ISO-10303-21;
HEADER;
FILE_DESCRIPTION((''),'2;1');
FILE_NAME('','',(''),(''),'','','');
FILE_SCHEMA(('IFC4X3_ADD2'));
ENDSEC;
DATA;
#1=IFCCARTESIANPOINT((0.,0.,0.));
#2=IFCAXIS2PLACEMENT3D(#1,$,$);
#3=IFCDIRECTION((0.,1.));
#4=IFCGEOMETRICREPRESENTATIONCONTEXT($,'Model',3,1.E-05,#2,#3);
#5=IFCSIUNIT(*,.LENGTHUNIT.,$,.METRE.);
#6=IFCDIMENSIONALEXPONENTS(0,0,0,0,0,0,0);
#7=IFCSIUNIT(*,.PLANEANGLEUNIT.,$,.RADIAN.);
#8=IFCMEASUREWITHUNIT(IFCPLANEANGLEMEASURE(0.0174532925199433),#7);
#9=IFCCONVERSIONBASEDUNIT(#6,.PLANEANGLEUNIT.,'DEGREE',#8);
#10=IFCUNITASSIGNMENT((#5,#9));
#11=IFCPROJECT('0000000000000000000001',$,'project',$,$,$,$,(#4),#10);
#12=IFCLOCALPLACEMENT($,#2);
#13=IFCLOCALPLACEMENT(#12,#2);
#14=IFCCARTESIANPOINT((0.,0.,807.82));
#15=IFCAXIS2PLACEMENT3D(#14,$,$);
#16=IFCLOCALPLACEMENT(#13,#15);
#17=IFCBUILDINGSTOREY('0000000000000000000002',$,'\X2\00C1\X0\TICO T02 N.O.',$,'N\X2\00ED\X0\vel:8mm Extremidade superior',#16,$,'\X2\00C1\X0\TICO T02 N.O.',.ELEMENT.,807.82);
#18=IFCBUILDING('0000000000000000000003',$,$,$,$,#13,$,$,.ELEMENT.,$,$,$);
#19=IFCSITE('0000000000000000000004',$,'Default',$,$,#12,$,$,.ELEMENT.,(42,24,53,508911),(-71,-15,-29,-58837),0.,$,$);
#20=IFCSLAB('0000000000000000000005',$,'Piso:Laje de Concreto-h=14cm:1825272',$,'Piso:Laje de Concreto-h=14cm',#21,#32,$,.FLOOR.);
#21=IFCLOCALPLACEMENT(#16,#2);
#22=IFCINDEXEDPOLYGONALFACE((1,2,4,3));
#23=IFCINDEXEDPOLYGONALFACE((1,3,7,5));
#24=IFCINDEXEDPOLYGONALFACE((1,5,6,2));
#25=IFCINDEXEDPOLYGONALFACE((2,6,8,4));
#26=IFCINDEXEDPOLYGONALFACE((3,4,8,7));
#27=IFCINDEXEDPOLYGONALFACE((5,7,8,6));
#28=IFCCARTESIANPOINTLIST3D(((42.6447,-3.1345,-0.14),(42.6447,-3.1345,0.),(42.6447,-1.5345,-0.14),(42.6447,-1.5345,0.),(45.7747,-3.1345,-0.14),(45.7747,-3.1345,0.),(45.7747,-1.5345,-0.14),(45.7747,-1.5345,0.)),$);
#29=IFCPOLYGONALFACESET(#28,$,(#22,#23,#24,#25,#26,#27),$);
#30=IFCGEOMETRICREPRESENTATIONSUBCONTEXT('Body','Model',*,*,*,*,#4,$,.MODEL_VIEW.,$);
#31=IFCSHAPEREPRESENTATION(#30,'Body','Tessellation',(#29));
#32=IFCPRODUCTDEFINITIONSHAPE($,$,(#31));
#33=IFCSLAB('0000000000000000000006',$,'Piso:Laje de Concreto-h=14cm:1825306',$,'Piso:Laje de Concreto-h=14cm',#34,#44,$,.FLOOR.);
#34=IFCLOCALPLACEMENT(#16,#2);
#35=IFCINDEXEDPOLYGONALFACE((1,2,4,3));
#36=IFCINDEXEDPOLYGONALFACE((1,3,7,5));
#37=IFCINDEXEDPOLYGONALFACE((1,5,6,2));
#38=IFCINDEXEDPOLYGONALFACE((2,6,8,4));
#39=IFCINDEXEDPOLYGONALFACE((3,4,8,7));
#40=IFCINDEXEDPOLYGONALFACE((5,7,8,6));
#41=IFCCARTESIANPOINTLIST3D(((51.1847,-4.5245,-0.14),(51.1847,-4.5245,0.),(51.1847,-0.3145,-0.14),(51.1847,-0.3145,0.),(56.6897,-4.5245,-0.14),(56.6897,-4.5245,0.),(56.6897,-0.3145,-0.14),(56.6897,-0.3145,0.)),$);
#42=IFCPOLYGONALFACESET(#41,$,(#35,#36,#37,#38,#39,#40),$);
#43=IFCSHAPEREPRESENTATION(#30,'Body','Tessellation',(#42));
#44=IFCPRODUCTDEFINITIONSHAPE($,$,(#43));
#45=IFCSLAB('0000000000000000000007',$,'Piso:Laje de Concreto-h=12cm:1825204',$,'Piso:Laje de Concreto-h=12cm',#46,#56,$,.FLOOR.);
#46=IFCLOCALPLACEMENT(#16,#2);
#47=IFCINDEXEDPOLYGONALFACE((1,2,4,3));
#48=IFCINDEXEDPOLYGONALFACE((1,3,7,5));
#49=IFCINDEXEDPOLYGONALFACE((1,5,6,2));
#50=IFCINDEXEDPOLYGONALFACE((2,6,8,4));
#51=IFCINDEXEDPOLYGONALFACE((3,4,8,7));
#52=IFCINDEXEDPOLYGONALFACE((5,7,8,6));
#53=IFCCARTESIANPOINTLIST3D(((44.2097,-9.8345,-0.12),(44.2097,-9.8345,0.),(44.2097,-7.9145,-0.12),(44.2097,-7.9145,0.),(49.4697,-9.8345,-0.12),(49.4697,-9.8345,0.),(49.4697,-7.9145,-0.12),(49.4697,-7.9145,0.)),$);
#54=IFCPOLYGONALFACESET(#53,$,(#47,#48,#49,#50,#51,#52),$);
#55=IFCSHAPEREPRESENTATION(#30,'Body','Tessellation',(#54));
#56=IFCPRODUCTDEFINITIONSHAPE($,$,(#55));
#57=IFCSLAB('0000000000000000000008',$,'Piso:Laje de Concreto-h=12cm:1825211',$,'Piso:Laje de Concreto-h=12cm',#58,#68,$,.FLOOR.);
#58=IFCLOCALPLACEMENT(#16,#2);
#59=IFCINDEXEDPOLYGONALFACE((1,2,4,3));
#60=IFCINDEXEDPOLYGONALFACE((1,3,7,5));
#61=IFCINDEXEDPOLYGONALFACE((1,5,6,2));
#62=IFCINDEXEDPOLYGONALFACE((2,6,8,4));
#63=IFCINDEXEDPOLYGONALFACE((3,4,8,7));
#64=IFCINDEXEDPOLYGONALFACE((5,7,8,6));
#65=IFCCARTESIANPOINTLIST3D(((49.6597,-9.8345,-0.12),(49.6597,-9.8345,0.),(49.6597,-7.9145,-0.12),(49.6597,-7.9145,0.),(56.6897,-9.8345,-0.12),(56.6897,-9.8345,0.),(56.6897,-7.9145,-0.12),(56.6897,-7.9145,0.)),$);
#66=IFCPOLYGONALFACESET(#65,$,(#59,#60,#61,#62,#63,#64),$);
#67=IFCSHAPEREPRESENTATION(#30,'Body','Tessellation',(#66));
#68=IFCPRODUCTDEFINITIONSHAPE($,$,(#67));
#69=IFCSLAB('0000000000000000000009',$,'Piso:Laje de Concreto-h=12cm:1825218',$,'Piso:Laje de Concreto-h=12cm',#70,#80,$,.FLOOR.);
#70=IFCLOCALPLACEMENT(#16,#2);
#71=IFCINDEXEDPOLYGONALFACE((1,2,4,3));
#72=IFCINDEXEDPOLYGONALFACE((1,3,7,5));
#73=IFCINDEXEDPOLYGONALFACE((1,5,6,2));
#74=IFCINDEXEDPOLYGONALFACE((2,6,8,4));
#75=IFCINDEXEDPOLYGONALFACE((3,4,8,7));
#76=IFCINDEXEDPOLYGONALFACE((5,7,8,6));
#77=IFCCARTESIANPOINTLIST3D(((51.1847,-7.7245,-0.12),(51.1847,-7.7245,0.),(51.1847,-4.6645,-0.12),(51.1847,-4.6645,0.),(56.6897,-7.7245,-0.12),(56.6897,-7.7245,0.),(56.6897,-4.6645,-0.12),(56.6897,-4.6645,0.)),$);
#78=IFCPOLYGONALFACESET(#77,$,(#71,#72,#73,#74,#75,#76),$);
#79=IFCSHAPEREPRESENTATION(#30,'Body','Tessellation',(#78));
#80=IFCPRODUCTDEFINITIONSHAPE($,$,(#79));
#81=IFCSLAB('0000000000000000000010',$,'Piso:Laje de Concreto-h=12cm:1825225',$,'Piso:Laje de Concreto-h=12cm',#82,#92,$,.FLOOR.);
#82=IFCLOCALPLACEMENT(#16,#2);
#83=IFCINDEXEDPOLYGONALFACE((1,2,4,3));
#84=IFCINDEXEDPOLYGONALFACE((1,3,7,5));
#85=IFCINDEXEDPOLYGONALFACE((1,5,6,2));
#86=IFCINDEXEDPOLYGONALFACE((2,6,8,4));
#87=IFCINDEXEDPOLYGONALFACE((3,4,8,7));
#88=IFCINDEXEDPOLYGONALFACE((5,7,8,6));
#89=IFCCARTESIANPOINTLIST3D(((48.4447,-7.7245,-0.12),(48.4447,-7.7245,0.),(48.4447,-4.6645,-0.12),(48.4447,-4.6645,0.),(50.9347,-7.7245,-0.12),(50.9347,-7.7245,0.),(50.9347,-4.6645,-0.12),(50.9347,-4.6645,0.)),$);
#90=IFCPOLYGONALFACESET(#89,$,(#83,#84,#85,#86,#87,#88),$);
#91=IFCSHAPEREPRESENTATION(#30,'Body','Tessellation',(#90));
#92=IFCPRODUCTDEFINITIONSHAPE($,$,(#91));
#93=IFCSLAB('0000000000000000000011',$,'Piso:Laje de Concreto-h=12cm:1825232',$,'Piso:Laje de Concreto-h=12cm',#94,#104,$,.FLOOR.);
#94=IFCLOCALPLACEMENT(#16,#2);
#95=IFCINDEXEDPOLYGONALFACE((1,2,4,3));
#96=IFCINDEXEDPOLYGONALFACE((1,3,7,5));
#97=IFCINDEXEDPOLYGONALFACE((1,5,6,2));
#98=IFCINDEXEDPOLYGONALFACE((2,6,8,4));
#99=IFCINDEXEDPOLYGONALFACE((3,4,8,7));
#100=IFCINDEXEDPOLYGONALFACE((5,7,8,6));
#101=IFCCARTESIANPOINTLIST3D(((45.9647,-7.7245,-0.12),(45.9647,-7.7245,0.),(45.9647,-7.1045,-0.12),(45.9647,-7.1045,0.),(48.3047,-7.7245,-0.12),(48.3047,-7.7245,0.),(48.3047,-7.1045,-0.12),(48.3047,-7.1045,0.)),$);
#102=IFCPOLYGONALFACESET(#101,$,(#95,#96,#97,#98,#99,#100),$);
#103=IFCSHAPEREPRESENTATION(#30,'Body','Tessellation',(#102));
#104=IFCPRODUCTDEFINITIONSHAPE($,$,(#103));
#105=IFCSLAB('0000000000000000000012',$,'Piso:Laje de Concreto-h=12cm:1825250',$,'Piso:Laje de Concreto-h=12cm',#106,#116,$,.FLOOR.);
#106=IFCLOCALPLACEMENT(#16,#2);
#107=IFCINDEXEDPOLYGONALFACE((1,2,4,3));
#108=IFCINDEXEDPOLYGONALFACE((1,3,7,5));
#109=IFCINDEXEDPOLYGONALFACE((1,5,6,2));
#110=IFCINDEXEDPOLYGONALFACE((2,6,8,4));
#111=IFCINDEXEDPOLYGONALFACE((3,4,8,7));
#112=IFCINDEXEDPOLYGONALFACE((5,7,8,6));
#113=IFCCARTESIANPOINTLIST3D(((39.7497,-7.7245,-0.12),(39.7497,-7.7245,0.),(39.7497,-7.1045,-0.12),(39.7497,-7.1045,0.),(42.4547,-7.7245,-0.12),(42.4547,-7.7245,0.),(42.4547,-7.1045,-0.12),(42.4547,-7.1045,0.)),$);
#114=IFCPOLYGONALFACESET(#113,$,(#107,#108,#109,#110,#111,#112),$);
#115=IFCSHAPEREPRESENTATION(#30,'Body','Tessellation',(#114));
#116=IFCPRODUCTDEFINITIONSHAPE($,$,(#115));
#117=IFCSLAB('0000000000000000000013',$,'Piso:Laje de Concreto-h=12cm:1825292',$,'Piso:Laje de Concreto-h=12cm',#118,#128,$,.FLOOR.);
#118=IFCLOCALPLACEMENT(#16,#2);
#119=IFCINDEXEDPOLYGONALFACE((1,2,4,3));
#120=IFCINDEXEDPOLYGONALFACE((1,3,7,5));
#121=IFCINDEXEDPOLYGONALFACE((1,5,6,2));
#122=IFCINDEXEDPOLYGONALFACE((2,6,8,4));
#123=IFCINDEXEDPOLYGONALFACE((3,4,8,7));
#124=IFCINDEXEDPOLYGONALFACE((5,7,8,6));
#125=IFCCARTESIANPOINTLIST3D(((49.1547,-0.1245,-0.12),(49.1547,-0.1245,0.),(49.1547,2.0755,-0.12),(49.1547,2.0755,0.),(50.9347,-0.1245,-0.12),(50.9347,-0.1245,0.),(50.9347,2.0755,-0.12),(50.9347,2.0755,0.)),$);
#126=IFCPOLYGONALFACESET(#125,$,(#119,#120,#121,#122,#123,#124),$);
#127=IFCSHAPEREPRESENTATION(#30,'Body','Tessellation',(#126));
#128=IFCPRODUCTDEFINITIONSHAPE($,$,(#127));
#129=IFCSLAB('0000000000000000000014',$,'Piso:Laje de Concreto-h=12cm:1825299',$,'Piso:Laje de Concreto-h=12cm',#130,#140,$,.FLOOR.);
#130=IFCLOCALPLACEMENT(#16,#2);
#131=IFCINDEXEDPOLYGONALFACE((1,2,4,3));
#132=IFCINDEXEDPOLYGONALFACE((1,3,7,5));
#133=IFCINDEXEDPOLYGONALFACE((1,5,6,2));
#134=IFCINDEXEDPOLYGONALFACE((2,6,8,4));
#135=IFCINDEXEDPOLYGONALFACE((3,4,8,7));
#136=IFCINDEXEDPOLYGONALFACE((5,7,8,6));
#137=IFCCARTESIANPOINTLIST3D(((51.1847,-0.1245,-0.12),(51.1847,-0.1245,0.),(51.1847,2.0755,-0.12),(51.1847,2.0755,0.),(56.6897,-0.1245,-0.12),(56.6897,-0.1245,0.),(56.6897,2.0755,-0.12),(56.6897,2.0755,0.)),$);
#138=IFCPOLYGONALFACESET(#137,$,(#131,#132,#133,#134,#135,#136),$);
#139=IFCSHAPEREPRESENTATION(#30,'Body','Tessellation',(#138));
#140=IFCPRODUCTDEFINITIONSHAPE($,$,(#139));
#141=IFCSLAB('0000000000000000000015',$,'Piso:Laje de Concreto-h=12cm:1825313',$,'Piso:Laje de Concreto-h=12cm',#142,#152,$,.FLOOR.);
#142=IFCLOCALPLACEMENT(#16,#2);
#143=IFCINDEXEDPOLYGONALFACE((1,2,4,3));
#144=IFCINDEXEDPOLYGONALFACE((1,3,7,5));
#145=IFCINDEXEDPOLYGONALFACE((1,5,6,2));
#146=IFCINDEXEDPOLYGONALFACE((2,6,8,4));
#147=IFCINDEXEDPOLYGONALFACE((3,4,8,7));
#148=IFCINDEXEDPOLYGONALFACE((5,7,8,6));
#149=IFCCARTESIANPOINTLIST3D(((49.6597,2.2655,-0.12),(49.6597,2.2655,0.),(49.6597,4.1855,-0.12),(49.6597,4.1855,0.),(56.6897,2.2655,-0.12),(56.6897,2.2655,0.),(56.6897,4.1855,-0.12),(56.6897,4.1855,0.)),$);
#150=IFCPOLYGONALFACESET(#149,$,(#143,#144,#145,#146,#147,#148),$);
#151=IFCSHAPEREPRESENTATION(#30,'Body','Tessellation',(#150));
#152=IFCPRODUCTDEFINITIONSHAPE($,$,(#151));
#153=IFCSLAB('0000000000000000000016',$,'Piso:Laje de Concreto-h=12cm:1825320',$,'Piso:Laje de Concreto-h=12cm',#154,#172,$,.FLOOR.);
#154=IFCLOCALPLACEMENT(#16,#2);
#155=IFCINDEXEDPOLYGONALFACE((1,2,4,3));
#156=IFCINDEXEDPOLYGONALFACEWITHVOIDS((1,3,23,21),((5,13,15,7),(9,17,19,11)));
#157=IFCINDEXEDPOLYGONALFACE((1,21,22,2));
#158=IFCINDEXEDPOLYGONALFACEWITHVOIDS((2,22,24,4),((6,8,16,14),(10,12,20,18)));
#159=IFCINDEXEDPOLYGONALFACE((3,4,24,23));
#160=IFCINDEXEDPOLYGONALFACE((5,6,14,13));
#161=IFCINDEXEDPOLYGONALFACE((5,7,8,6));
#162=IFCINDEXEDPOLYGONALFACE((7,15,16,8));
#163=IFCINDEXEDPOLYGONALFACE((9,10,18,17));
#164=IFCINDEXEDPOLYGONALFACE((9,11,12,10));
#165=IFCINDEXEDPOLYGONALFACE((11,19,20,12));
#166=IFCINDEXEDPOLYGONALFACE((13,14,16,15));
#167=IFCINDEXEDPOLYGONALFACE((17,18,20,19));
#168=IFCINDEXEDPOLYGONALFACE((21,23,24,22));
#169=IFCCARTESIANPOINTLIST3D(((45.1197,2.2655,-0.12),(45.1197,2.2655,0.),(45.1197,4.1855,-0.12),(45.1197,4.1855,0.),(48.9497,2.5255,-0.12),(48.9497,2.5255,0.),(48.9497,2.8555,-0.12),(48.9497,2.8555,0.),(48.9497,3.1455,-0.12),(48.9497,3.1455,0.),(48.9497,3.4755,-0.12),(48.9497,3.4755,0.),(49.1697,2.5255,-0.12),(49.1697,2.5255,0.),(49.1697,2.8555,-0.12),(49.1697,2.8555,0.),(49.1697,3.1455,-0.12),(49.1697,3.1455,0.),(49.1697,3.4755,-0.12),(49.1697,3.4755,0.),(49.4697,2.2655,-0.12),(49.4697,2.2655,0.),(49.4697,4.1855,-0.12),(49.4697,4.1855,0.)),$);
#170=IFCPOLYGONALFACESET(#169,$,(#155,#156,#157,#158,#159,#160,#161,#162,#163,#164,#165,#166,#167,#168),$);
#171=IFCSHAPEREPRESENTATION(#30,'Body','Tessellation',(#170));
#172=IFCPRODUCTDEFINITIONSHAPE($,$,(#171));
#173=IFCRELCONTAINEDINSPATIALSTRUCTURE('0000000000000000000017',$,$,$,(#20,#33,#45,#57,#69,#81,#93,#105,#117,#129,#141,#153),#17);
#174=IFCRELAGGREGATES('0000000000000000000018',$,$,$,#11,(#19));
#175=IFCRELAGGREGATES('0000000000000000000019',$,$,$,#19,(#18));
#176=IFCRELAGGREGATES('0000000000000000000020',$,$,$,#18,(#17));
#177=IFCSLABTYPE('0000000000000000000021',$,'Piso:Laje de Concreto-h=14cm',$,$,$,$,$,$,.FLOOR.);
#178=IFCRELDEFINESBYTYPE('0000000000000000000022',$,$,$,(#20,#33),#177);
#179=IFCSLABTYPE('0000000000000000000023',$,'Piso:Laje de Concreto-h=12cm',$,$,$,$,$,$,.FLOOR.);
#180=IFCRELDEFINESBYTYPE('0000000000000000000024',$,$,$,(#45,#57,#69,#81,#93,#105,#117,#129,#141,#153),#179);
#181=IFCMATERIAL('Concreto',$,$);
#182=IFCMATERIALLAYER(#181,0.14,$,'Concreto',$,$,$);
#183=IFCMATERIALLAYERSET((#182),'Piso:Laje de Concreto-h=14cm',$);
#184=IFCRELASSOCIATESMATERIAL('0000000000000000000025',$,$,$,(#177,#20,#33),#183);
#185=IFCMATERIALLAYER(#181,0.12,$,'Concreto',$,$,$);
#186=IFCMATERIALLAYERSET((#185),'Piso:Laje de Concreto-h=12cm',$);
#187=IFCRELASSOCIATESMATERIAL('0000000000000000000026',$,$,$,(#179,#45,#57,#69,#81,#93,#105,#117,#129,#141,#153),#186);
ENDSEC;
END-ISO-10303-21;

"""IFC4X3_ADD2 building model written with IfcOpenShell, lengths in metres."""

from ifc_helpers import new_model, entity, si_unit, converted_unit, direction, frame, frame_2d, origin, origin_2d_with_axis, place, context, subcontext, project, spatial, rectangle, extrude, boolean, material, layer, layer_set, layer_usage, type_object, element, save


model = new_model("IFC4X3_ADD2")

# Units and contexts
model_context = context("Model", 3, precision=1e-05, world=origin(), true_north=direction((0.0, 1.0)))
body_context = subcontext(model_context, "Body", "Model", "MODEL_VIEW")
ifc_project = project(units=[si_unit("LENGTHUNIT", "METRE"), converted_unit("PLANEANGLEUNIT", "DEGREE", entity("IfcPlaneAngleMeasure", 0.0174532925199433), si_unit("PLANEANGLEUNIT", "RADIAN"), dimensions=[0, 0, 0, 0, 0, 0, 0])], contexts=[model_context])

# Site, building, storey
site_placement = place(None, origin())
site = spatial("IfcSite", under=ifc_project, at=site_placement, Name="Default", CompositionType="ELEMENT", RefLatitude=(42, 24, 53, 508911), RefLongitude=(-71, -15, -29, -58837), RefElevation=0.0)
building_placement = place(site_placement, origin())
building = spatial("IfcBuilding", under=site, at=building_placement, CompositionType="ELEMENT")
storey_placement = place(building_placement, frame((0.0, 0.0, 807.82)))
storey = spatial("IfcBuildingStorey", under=building, at=storey_placement, Name="ÁTICO T02 N.O.", ObjectType="Nível:8mm Extremidade superior", LongName="ÁTICO T02 N.O.", CompositionType="ELEMENT", Elevation=807.82)

# Slabs
ifc_material = material(Name="Concreto")
ifc_layer_1 = layer(ifc_material, 0.14, Name="Concreto")
ifc_layer_set_1 = layer_set([ifc_layer_1], Name="Piso:Laje de Concreto-h=14cm")
slab_type_1 = type_object("IfcSlabType", Name="Piso:Laje de Concreto-h=14cm", PredefinedType="FLOOR", material=ifc_layer_set_1)
ifc_layer_usage_1 = layer_usage(ifc_layer_set_1, "AXIS3", "POSITIVE", 0.0)
slab_1_placement = place(storey_placement, origin())
element("IfcSlab", 1, at=slab_1_placement, inside=storey, type_object=slab_type_1, material=ifc_layer_usage_1, Name="Piso:Laje de Concreto-h=14cm:1825272", ObjectType="Piso:Laje de Concreto-h=14cm", PredefinedType="FLOOR", context=body_context, shape_type="SweptSolid", body=[
    extrude(rectangle(XDim=1.6, YDim=3.13, at=origin_2d_with_axis()), frame((44.2097, -2.3345, 0.0), z_axis=(0.0, 0.0, -1.0), x_axis=(0.0, 1.0, 0.0)), (0.0, 0.0, 1.0), 0.14),
])
ifc_layer_usage_2 = layer_usage(ifc_layer_set_1, "AXIS3", "POSITIVE", 0.0)
slab_2_placement = place(storey_placement, origin())
element("IfcSlab", 2, at=slab_2_placement, inside=storey, type_object=slab_type_1, material=ifc_layer_usage_2, Name="Piso:Laje de Concreto-h=14cm:1825306", ObjectType="Piso:Laje de Concreto-h=14cm", PredefinedType="FLOOR", context=body_context, shape_type="SweptSolid", body=[
    extrude(rectangle(XDim=4.21, YDim=5.505, at=origin_2d_with_axis()), frame((53.9372, -2.4195, 0.0), z_axis=(0.0, 0.0, -1.0), x_axis=(0.0, 1.0, 0.0)), (0.0, 0.0, 1.0), 0.14),
])
ifc_layer_2 = layer(ifc_material, 0.12, Name="Concreto")
ifc_layer_set_2 = layer_set([ifc_layer_2], Name="Piso:Laje de Concreto-h=12cm")
slab_type_2 = type_object("IfcSlabType", Name="Piso:Laje de Concreto-h=12cm", PredefinedType="FLOOR", material=ifc_layer_set_2)
ifc_layer_usage_3 = layer_usage(ifc_layer_set_2, "AXIS3", "POSITIVE", 0.0)
slab_3_placement = place(storey_placement, origin())
element("IfcSlab", 3, at=slab_3_placement, inside=storey, type_object=slab_type_2, material=ifc_layer_usage_3, Name="Piso:Laje de Concreto-h=12cm:1825204", ObjectType="Piso:Laje de Concreto-h=12cm", PredefinedType="FLOOR", context=body_context, shape_type="SweptSolid", body=[
    extrude(rectangle(XDim=1.92, YDim=5.26, at=frame_2d((0.0, 0.0), x_axis=(1.0, 0.0))), frame((46.8397, -8.8745, 0.0), z_axis=(0.0, 0.0, -1.0), x_axis=(0.0, 1.0, 0.0)), (0.0, 0.0, 1.0), 0.12),
])
ifc_layer_usage_4 = layer_usage(ifc_layer_set_2, "AXIS3", "POSITIVE", 0.0)
slab_4_placement = place(storey_placement, origin())
element("IfcSlab", 4, at=slab_4_placement, inside=storey, type_object=slab_type_2, material=ifc_layer_usage_4, Name="Piso:Laje de Concreto-h=12cm:1825211", ObjectType="Piso:Laje de Concreto-h=12cm", PredefinedType="FLOOR", context=body_context, shape_type="SweptSolid", body=[
    extrude(rectangle(XDim=1.92, YDim=7.03, at=frame_2d((0.0, 0.0), x_axis=(1.0, 0.0))), frame((53.1747, -8.8745, 0.0), z_axis=(0.0, 0.0, -1.0), x_axis=(0.0, 1.0, 0.0)), (0.0, 0.0, 1.0), 0.12),
])
ifc_layer_usage_5 = layer_usage(ifc_layer_set_2, "AXIS3", "POSITIVE", 0.0)
slab_5_placement = place(storey_placement, origin())
element("IfcSlab", 5, at=slab_5_placement, inside=storey, type_object=slab_type_2, material=ifc_layer_usage_5, Name="Piso:Laje de Concreto-h=12cm:1825218", ObjectType="Piso:Laje de Concreto-h=12cm", PredefinedType="FLOOR", context=body_context, shape_type="SweptSolid", body=[
    extrude(rectangle(XDim=3.06, YDim=5.505, at=origin_2d_with_axis()), frame((53.9372, -6.1945, 0.0), z_axis=(0.0, 0.0, -1.0), x_axis=(0.0, 1.0, 0.0)), (0.0, 0.0, 1.0), 0.12),
])
ifc_layer_usage_6 = layer_usage(ifc_layer_set_2, "AXIS3", "POSITIVE", 0.0)
slab_6_placement = place(storey_placement, origin())
element("IfcSlab", 6, at=slab_6_placement, inside=storey, type_object=slab_type_2, material=ifc_layer_usage_6, Name="Piso:Laje de Concreto-h=12cm:1825225", ObjectType="Piso:Laje de Concreto-h=12cm", PredefinedType="FLOOR", context=body_context, shape_type="SweptSolid", body=[
    extrude(rectangle(XDim=3.06, YDim=2.49, at=frame_2d((0.0, 0.0), x_axis=(1.0, 0.0))), frame((49.6897, -6.1945, 0.0), z_axis=(0.0, 0.0, -1.0), x_axis=(0.0, 1.0, 0.0)), (0.0, 0.0, 1.0), 0.12),
])
ifc_layer_usage_7 = layer_usage(ifc_layer_set_2, "AXIS3", "POSITIVE", 0.0)
slab_7_placement = place(storey_placement, origin())
element("IfcSlab", 7, at=slab_7_placement, inside=storey, type_object=slab_type_2, material=ifc_layer_usage_7, Name="Piso:Laje de Concreto-h=12cm:1825232", ObjectType="Piso:Laje de Concreto-h=12cm", PredefinedType="FLOOR", context=body_context, shape_type="SweptSolid", body=[
    extrude(rectangle(XDim=0.62, YDim=2.34, at=origin_2d_with_axis()), frame((47.1347, -7.4145, 0.0), z_axis=(0.0, 0.0, -1.0), x_axis=(0.0, 1.0, 0.0)), (0.0, 0.0, 1.0), 0.12),
])
ifc_layer_usage_8 = layer_usage(ifc_layer_set_2, "AXIS3", "POSITIVE", 0.0)
slab_8_placement = place(storey_placement, origin())
element("IfcSlab", 8, at=slab_8_placement, inside=storey, type_object=slab_type_2, material=ifc_layer_usage_8, Name="Piso:Laje de Concreto-h=12cm:1825250", ObjectType="Piso:Laje de Concreto-h=12cm", PredefinedType="FLOOR", context=body_context, shape_type="SweptSolid", body=[
    extrude(rectangle(XDim=0.62, YDim=2.705, at=origin_2d_with_axis()), frame((41.1022, -7.4145, 0.0), z_axis=(0.0, 0.0, -1.0), x_axis=(0.0, 1.0, 0.0)), (0.0, 0.0, 1.0), 0.12),
])

# Slabs
ifc_layer_usage_9 = layer_usage(ifc_layer_set_2, "AXIS3", "POSITIVE", 0.0)
slab_9_placement = place(storey_placement, origin())
element("IfcSlab", 9, at=slab_9_placement, inside=storey, type_object=slab_type_2, material=ifc_layer_usage_9, Name="Piso:Laje de Concreto-h=12cm:1825292", ObjectType="Piso:Laje de Concreto-h=12cm", PredefinedType="FLOOR", context=body_context, shape_type="SweptSolid", body=[
    extrude(rectangle(XDim=2.2, YDim=1.78, at=origin_2d_with_axis()), frame((50.0447, 0.9755, 0.0), z_axis=(0.0, 0.0, -1.0), x_axis=(0.0, 1.0, 0.0)), (0.0, 0.0, 1.0), 0.12),
])
ifc_layer_usage_10 = layer_usage(ifc_layer_set_2, "AXIS3", "POSITIVE", 0.0)
slab_10_placement = place(storey_placement, origin())
element("IfcSlab", 10, at=slab_10_placement, inside=storey, type_object=slab_type_2, material=ifc_layer_usage_10, Name="Piso:Laje de Concreto-h=12cm:1825299", ObjectType="Piso:Laje de Concreto-h=12cm", PredefinedType="FLOOR", context=body_context, shape_type="SweptSolid", body=[
    extrude(rectangle(XDim=2.2, YDim=5.505, at=frame_2d((0.0, 0.0), x_axis=(1.0, 0.0))), frame((53.9372, 0.9755, 0.0), z_axis=(0.0, 0.0, -1.0), x_axis=(0.0, 1.0, 0.0)), (0.0, 0.0, 1.0), 0.12),
])
ifc_layer_usage_11 = layer_usage(ifc_layer_set_2, "AXIS3", "POSITIVE", 0.0)
slab_11_placement = place(storey_placement, origin())
element("IfcSlab", 11, at=slab_11_placement, inside=storey, type_object=slab_type_2, material=ifc_layer_usage_11, Name="Piso:Laje de Concreto-h=12cm:1825313", ObjectType="Piso:Laje de Concreto-h=12cm", PredefinedType="FLOOR", context=body_context, shape_type="SweptSolid", body=[
    extrude(rectangle(XDim=1.92, YDim=7.03, at=frame_2d((0.0, 0.0), x_axis=(1.0, 0.0))), frame((53.1747, 3.2255, 0.0), z_axis=(0.0, 0.0, -1.0), x_axis=(0.0, 1.0, 0.0)), (0.0, 0.0, 1.0), 0.12),
])

# Slab, openings
ifc_layer_usage_12 = layer_usage(ifc_layer_set_2, "AXIS3", "POSITIVE", 0.0)
slab_12_placement = place(storey_placement, origin())
slab_12 = element("IfcSlab", 12, at=slab_12_placement, inside=storey, type_object=slab_type_2, material=ifc_layer_usage_12, Name="Piso:Laje de Concreto-h=12cm:1825320", ObjectType="Piso:Laje de Concreto-h=12cm", PredefinedType="FLOOR", context=body_context, shape_type="CSG", body=[
    boolean("DIFFERENCE", boolean("DIFFERENCE", extrude(rectangle(XDim=1.92, YDim=4.35, at=origin_2d_with_axis()), frame((47.2947, 3.2255, 0.0), z_axis=(0.0, 0.0, -1.0), x_axis=(0.0, 1.0, 0.0)), (0.0, 0.0, 1.0), 0.12), extrude(rectangle(XDim=0.33, YDim=0.22, at=frame_2d((0.0, 0.0), x_axis=(1.0, 0.0))), frame((49.0597, 2.6905, -0.12), z_axis=(0.0, 0.0, 1.0), x_axis=(0.0, 1.0, 0.0)), (0.0, 0.0, 1.0), 0.12)), extrude(rectangle(XDim=0.33, YDim=0.22, at=frame_2d((0.0, 0.0), x_axis=(1.0, 0.0))), frame((49.0597, 3.3105, -0.12), z_axis=(0.0, 0.0, 1.0), x_axis=(0.0, 1.0, 0.0)), (0.0, 0.0, 1.0), 0.12)),
])
opening_1_placement = place(slab_12_placement, origin())
element("IfcOpeningElement", 13, at=opening_1_placement, cuts=slab_12, PredefinedType="OPENING", context=body_context, shape_type="SweptSolid", body=[
    extrude(rectangle(XDim=0.33, YDim=0.22, at=frame_2d((49.0597, 3.3105), x_axis=(0.0, -1.0))), origin(), (0.0, 0.0, -1.0), 0.12),
])
opening_2_placement = place(slab_12_placement, origin())
element("IfcOpeningElement", 14, at=opening_2_placement, cuts=slab_12, PredefinedType="OPENING", context=body_context, shape_type="SweptSolid", body=[
    extrude(rectangle(XDim=0.33, YDim=0.22, at=frame_2d((49.0597, 2.6905), x_axis=(0.0, -1.0))), origin(), (0.0, 0.0, -1.0), 0.12),
])

save(model, "model.ifc")
